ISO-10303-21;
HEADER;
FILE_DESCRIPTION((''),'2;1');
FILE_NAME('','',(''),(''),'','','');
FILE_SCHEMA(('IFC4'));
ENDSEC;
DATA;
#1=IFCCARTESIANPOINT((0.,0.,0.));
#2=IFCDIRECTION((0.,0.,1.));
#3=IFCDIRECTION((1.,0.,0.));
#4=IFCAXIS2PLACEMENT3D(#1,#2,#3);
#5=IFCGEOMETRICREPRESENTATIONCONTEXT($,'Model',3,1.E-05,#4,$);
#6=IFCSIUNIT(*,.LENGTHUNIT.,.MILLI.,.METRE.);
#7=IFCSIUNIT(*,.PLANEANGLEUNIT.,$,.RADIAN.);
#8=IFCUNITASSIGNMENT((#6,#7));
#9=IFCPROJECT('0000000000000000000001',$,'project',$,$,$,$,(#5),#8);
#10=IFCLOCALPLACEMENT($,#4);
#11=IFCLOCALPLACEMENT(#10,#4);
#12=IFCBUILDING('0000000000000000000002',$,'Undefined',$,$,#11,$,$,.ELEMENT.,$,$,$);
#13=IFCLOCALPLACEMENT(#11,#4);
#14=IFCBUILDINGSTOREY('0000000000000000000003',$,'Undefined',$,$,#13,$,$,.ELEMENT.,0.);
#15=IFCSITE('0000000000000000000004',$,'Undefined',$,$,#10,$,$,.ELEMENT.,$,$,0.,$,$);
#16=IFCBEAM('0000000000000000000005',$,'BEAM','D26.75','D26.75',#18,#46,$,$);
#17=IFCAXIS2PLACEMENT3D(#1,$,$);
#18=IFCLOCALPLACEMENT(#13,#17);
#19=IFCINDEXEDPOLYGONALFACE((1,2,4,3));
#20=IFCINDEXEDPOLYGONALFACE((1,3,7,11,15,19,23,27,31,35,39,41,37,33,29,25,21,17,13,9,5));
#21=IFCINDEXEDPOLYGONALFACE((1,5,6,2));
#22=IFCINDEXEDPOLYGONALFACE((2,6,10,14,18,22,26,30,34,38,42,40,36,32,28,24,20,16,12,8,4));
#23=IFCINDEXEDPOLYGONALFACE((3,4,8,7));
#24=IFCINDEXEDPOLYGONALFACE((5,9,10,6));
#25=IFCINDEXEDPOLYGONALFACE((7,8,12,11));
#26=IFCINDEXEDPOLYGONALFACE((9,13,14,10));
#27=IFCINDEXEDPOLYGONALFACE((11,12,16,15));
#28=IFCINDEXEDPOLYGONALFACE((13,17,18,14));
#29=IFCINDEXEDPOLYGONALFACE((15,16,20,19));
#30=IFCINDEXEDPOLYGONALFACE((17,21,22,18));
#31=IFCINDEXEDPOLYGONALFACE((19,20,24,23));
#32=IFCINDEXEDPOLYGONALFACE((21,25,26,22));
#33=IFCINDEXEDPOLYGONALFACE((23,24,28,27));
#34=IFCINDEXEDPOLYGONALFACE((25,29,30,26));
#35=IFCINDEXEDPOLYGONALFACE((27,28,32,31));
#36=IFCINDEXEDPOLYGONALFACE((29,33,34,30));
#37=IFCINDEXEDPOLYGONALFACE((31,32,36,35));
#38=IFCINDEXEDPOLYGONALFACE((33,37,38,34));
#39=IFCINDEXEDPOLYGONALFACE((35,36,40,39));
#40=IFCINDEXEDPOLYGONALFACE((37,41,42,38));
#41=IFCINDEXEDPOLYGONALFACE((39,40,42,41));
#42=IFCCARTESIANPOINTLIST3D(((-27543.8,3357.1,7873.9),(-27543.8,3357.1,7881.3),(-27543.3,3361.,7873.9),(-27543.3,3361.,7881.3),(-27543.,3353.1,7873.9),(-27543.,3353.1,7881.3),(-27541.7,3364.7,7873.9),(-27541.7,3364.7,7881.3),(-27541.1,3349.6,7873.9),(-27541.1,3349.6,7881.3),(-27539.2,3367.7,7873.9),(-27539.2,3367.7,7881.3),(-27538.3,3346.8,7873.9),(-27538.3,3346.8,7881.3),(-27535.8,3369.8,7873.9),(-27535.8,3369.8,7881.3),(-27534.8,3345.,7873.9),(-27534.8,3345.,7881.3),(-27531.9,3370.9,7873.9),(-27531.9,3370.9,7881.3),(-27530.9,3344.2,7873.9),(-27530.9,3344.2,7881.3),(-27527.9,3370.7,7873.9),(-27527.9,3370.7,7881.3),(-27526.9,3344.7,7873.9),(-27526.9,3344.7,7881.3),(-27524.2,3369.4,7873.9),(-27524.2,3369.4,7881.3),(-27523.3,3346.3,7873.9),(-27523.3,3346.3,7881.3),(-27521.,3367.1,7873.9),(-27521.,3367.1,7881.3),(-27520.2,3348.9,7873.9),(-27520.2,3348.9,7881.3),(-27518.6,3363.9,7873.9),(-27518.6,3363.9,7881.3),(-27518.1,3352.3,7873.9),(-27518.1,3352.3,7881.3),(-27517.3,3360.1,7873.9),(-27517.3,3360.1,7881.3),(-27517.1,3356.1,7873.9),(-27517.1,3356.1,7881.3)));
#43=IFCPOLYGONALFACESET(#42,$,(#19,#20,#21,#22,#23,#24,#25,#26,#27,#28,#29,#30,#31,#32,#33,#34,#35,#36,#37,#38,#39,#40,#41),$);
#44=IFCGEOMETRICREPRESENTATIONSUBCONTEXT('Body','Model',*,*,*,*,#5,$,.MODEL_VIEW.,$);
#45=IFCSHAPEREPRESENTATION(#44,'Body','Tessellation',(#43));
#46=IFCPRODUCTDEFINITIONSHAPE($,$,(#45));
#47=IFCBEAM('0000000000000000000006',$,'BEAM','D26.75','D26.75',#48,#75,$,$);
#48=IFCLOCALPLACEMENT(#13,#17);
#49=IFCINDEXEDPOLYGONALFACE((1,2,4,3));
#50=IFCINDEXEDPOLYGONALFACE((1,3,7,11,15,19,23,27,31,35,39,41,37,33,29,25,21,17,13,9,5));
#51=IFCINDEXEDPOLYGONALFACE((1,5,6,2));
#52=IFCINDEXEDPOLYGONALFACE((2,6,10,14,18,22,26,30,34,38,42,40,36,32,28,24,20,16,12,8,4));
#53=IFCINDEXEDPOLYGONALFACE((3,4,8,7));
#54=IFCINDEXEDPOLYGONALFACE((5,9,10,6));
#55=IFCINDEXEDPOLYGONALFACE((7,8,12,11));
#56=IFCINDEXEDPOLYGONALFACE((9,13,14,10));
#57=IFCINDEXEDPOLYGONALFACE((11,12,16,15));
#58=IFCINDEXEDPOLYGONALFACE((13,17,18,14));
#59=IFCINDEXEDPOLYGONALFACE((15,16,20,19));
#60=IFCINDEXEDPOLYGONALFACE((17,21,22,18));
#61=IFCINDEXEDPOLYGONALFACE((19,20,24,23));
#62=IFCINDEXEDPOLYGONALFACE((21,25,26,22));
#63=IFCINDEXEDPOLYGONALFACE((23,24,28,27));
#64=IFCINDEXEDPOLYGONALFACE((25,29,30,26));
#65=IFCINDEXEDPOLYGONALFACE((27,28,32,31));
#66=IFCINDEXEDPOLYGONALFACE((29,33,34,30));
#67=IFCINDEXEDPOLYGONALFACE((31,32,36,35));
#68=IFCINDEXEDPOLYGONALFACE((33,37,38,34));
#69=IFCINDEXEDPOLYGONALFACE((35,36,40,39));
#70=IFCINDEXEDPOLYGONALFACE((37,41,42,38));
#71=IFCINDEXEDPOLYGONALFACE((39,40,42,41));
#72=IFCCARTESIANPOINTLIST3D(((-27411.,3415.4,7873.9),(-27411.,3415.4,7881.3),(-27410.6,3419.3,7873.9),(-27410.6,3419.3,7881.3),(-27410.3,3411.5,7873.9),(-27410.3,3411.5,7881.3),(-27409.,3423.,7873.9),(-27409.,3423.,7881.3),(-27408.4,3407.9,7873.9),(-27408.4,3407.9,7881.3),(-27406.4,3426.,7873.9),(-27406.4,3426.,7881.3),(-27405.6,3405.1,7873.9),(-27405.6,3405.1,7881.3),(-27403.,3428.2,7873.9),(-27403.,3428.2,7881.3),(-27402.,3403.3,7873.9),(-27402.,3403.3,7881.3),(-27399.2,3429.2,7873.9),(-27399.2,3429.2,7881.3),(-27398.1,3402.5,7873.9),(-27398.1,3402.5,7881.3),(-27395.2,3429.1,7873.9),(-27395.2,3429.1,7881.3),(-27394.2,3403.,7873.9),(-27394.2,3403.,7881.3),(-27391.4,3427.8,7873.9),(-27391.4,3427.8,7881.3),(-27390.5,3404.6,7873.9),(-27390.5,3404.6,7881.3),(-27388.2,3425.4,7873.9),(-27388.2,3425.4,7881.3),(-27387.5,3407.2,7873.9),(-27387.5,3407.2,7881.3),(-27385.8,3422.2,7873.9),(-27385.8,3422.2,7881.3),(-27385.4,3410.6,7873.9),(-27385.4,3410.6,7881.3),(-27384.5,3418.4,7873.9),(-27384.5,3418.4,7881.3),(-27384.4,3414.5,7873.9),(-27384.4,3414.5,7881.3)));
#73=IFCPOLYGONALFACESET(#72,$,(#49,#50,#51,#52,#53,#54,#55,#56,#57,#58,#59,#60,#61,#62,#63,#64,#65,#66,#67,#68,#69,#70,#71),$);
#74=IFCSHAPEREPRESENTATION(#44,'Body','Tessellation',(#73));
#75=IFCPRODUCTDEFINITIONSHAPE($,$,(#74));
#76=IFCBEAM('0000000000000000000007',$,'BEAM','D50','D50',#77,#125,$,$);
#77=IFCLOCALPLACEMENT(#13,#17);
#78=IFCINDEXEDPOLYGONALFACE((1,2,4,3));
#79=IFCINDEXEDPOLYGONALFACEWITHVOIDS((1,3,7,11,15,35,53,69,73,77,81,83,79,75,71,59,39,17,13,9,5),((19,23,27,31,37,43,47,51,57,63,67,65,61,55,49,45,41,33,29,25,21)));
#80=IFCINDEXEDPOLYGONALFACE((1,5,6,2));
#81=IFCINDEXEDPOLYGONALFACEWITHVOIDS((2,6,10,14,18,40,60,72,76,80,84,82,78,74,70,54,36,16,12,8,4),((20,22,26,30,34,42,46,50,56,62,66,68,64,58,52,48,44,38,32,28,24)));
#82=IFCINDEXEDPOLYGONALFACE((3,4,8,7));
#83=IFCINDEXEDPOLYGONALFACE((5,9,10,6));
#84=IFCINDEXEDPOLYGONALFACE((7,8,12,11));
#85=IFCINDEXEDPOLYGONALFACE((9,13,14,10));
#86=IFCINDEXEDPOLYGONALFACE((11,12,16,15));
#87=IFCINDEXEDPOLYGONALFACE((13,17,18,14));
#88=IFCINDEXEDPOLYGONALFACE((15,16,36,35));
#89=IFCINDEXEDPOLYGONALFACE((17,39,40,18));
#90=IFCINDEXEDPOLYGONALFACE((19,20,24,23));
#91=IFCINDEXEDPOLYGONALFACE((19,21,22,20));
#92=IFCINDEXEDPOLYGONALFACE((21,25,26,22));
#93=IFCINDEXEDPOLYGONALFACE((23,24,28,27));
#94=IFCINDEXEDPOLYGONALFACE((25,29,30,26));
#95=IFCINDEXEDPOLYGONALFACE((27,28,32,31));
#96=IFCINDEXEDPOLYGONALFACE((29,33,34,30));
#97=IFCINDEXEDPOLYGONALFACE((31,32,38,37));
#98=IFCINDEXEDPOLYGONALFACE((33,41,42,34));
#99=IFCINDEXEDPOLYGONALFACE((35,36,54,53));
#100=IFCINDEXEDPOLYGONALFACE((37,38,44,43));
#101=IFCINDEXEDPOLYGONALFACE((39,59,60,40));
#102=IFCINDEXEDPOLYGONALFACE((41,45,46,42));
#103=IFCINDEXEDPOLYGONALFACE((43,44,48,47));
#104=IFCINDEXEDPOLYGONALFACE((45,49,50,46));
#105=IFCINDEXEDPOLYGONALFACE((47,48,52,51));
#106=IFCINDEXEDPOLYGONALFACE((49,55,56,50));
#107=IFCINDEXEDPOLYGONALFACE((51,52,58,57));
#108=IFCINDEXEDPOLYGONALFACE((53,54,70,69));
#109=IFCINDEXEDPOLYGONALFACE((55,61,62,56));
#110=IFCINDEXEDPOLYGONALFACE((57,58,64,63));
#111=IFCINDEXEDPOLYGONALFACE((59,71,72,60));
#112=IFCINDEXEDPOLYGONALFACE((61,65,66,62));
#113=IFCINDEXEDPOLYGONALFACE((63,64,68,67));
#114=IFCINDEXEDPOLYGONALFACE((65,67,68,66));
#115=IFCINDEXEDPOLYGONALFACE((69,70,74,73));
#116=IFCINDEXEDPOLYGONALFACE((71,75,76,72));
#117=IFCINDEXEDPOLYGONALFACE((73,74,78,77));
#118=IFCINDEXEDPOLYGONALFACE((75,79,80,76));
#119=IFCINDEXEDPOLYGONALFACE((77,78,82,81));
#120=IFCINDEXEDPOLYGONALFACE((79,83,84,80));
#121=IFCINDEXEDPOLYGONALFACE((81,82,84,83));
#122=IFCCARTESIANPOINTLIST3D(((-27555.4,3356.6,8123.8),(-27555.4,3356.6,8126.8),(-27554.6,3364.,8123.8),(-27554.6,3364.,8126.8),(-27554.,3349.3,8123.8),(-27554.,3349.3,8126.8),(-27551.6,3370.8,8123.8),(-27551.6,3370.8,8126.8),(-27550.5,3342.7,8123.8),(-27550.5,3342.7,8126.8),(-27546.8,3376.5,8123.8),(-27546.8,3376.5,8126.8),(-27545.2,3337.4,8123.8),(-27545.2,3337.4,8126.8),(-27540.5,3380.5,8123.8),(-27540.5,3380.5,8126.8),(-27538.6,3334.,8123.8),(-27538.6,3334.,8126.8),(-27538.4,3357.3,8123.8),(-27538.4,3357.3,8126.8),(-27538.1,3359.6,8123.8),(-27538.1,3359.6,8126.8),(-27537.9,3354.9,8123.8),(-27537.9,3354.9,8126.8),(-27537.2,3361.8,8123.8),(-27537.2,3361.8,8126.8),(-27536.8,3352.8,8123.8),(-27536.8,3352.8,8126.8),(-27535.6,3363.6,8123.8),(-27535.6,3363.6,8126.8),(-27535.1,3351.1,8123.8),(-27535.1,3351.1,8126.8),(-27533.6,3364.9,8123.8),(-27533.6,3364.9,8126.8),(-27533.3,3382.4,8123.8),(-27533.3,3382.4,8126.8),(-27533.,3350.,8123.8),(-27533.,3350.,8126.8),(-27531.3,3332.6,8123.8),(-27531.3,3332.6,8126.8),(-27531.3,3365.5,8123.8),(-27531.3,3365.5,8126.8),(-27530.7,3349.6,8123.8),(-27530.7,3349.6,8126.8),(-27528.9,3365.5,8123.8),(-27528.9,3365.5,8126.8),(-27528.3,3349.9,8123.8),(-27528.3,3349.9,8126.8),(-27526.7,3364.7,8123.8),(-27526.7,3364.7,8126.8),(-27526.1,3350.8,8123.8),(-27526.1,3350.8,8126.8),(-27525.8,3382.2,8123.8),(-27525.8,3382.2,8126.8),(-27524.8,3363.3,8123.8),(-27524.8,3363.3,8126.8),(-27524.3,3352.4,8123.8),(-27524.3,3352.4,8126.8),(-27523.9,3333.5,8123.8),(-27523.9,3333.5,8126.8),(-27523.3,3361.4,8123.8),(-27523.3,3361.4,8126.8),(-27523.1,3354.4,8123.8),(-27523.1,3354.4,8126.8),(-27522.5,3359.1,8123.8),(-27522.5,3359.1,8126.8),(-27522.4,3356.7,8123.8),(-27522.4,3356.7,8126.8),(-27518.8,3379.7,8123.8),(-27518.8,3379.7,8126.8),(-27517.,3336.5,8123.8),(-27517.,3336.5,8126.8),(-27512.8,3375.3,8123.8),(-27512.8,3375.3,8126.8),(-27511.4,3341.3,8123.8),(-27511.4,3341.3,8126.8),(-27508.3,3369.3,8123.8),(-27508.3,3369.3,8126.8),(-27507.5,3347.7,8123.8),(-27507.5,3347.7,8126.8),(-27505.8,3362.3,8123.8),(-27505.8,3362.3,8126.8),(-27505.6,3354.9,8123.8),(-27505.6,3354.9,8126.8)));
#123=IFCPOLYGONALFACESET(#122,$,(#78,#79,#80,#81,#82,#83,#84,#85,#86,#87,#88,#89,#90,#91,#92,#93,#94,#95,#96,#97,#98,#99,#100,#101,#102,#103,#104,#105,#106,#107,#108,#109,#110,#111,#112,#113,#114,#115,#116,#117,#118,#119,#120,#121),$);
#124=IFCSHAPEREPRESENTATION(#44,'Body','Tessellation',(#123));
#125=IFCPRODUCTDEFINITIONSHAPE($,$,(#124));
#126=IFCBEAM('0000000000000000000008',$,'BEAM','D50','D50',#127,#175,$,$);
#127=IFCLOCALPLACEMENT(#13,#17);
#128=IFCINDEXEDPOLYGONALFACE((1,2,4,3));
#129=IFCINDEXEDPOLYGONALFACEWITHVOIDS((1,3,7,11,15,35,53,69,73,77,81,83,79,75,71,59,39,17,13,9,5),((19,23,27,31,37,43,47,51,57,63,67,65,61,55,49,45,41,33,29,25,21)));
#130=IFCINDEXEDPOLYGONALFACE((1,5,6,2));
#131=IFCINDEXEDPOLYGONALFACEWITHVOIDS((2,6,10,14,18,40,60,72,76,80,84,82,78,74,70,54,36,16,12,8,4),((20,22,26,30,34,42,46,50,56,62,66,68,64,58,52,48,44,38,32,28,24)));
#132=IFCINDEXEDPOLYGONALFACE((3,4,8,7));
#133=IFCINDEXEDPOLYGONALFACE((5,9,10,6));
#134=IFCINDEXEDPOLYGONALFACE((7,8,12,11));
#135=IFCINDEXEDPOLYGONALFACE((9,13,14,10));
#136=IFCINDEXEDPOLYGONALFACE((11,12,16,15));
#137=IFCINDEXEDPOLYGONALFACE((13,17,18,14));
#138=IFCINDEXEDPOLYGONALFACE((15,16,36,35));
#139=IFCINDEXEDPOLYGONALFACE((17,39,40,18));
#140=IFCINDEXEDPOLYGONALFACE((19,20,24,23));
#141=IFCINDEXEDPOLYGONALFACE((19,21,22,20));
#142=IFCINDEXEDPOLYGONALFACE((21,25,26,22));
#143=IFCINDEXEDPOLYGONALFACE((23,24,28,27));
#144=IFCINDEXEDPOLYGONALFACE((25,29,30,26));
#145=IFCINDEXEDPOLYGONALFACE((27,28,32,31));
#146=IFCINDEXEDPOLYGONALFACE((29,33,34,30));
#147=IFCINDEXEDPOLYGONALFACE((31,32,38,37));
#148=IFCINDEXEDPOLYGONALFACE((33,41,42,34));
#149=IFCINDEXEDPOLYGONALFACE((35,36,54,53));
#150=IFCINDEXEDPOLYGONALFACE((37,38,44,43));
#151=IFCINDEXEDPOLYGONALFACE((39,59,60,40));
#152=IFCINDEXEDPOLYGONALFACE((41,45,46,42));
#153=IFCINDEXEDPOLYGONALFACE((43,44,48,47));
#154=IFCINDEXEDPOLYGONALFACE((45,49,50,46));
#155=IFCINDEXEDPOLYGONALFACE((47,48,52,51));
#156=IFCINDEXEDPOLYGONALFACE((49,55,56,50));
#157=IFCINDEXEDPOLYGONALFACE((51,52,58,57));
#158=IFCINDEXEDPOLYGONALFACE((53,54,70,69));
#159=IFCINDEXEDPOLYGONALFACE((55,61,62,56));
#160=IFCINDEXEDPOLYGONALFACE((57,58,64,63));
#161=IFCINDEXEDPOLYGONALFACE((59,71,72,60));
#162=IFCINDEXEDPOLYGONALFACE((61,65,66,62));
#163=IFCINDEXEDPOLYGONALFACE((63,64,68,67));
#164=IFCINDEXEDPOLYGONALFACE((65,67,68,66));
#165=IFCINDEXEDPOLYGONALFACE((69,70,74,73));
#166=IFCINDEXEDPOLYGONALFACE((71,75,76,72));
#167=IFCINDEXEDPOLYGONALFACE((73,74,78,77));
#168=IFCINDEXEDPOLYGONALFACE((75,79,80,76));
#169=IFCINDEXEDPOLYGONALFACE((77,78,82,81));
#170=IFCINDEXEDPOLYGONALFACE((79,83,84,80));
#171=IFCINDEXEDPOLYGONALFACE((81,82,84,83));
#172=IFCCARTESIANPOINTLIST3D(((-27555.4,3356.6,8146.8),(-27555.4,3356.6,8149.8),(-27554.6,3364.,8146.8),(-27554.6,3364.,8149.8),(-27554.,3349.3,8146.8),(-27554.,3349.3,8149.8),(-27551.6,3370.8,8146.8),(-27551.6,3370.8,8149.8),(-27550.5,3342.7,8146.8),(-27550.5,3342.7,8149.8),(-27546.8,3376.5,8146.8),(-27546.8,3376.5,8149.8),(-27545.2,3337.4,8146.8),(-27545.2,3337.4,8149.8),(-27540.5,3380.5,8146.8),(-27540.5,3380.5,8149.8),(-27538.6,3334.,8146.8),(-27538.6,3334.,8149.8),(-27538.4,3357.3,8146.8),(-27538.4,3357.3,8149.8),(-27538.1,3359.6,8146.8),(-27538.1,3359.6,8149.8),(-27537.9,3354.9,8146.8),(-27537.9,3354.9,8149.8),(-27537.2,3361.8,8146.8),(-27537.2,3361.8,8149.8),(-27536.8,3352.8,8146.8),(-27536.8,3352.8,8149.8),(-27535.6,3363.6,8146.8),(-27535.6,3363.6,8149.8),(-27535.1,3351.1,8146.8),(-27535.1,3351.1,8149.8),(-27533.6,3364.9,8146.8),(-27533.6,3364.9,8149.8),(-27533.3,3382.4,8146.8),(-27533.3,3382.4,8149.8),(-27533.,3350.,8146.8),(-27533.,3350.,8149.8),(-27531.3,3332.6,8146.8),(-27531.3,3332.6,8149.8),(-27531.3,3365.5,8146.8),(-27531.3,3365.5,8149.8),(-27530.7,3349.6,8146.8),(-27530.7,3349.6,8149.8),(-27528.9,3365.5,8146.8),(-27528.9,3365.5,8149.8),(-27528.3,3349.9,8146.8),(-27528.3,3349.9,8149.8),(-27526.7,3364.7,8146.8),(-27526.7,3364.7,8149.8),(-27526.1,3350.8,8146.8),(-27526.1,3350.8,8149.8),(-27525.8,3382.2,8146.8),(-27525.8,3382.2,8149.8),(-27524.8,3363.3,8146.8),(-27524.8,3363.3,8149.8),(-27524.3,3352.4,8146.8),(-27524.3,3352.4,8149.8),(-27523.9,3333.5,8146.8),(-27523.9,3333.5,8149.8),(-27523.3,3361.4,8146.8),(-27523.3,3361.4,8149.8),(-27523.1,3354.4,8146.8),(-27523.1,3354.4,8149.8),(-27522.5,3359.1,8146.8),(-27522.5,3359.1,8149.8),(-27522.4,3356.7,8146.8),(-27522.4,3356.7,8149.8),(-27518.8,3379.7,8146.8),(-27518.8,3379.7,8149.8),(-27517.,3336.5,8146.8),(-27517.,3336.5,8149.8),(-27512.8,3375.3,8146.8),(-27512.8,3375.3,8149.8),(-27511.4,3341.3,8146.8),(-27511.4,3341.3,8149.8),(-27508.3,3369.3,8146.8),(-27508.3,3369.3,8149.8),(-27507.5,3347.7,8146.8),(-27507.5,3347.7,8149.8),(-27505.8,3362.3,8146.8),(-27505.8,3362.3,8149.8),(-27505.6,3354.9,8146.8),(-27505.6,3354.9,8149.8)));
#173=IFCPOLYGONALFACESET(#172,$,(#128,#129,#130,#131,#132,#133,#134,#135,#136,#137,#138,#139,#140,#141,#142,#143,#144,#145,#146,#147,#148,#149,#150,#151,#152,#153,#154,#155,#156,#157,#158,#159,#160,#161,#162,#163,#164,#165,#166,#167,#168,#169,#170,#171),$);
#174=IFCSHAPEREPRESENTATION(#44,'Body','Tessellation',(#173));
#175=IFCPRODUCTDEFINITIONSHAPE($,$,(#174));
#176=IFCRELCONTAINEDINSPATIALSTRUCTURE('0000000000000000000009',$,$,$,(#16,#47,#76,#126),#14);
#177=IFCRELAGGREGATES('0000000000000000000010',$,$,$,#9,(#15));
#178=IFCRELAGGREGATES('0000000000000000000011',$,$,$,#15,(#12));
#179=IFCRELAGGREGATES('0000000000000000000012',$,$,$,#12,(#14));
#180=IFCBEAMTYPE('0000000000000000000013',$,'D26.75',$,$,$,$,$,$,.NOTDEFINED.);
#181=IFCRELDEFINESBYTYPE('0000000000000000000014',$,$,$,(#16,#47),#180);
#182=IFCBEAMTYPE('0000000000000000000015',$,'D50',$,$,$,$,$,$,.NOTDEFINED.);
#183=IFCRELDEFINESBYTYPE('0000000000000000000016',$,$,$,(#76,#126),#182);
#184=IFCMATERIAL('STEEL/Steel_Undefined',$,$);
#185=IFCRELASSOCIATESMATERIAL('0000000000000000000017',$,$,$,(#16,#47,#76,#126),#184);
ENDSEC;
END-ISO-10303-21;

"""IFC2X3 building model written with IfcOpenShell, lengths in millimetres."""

from ifc_helpers import new_model, si_unit, frame, origin_with_axes, origin_2d_with_axis, place, context, subcontext, project, spatial, circle, extrude, material, type_object, element, save


model = new_model("IFC2X3")

# Units and contexts
model_context = context("Model", 3, precision=1e-05, world=origin_with_axes())
body_context = subcontext(model_context, "Body", "Model", "MODEL_VIEW")
ifc_project = project(units=[si_unit("LENGTHUNIT", "METRE", prefix="MILLI"), si_unit("PLANEANGLEUNIT", "RADIAN")], contexts=[model_context])

# Site, building, storey
site_placement = place(None, origin_with_axes())
site = spatial("IfcSite", under=ifc_project, at=site_placement, Name="Undefined", CompositionType="ELEMENT", RefElevation=0.0)
building_placement = place(site_placement, origin_with_axes())
building = spatial("IfcBuilding", under=site, at=building_placement, Name="Undefined", CompositionType="ELEMENT")
storey_placement = place(building_placement, origin_with_axes())
storey = spatial("IfcBuildingStorey", under=building, at=storey_placement, Name="Undefined", CompositionType="ELEMENT", Elevation=0.0)

# Shared definitions
ifc_material = material(Name="STEEL/Steel_Undefined")
beam_type_1 = type_object("IfcBeamType", Name="D26.75", PredefinedType="NOTDEFINED")

# Beam
beam_1_placement = place(storey_placement, frame((-27530.4, 3357.6, 7881.3), z_axis=(-0.915553, -0.402198, 0.0), x_axis=(0.0, 0.0, -1.0)))
element("IfcBeam", 1, at=beam_1_placement, inside=storey, type_object=beam_type_1, material=ifc_material, Name="BEAM", Description="D26.75", ObjectType="D26.75", context=body_context, shape_type="SweptSolid", body=[
    extrude(circle(Radius=13.4, at=origin_2d_with_axis()), frame((7.4, 0.0, 0.0), z_axis=(-1.0, 0.0, 0.0), x_axis=(0.0, -1.0, 0.0)), (0.0, 0.0, 1.0), 7.4),
])

# Beam
beam_2_placement = place(storey_placement, frame((-27397.6, 3415.9, 7881.3), z_axis=(-0.915553, -0.402198, 0.0), x_axis=(0.0, 0.0, -1.0)))
element("IfcBeam", 2, at=beam_2_placement, inside=storey, type_object=beam_type_1, material=ifc_material, Name="BEAM", Description="D26.75", ObjectType="D26.75", context=body_context, shape_type="SweptSolid", body=[
    extrude(circle(Radius=13.4, at=origin_2d_with_axis()), frame((7.4, 0.0, 0.0), z_axis=(-1.0, 0.0, 0.0), x_axis=(0.0, -1.0, 0.0)), (0.0, 0.0, 1.0), 7.4),
])

# Beams, openings
beam_type_2 = type_object("IfcBeamType", Name="D50", PredefinedType="NOTDEFINED")
beam_3_placement = place(storey_placement, frame((-27530.4, 3357.6, 8126.8), z_axis=(-0.915553, -0.402198, 0.0), x_axis=(0.0, 0.0, -1.0)))
beam_3 = element("IfcBeam", 3, at=beam_3_placement, inside=storey, type_object=beam_type_2, material=ifc_material, Name="BEAM", Description="D50", ObjectType="D50", context=body_context, shape_type="SweptSolid", body=[
    extrude(circle(Radius=25.0, at=origin_2d_with_axis()), frame((3.0, 0.0, 0.0), z_axis=(-1.0, 0.0, 0.0), x_axis=(0.0, -1.0, 0.0)), (0.0, 0.0, 1.0), 3.0),
])
opening_1_placement = place(storey_placement, frame((-27530.4, 3357.6, 8126.8), z_axis=(-0.915553, -0.402198, 0.0), x_axis=(0.0, 0.0, -1.0)))
element("IfcOpeningElement", 4, at=opening_1_placement, cuts=beam_3, ObjectType="Recess", context=body_context, shape_type="SweptSolid", body=[
    extrude(circle(Radius=8.0, at=origin_2d_with_axis()), frame((245.5, 0.0, 0.0), z_axis=(-1.0, 0.0, 0.0), x_axis=(0.0, -1.0, 0.0)), (0.0, 0.0, 1.0), 292.6),
])
beam_4_placement = place(storey_placement, frame((-27530.4, 3357.6, 8149.8), z_axis=(-0.915553, -0.402198, 0.0), x_axis=(0.0, 0.0, -1.0)))
beam_4 = element("IfcBeam", 5, at=beam_4_placement, inside=storey, type_object=beam_type_2, material=ifc_material, Name="BEAM", Description="D50", ObjectType="D50", context=body_context, shape_type="SweptSolid", body=[
    extrude(circle(Radius=25.0, at=origin_2d_with_axis()), frame((3.0, 0.0, 0.0), z_axis=(-1.0, 0.0, 0.0), x_axis=(0.0, -1.0, 0.0)), (0.0, 0.0, 1.0), 3.0),
])
opening_2_placement = place(storey_placement, frame((-27530.4, 3357.6, 8149.8), z_axis=(-0.915553, -0.402198, 0.0), x_axis=(0.0, 0.0, -1.0)))
element("IfcOpeningElement", 6, at=opening_2_placement, cuts=beam_4, ObjectType="Recess", context=body_context, shape_type="SweptSolid", body=[
    extrude(circle(Radius=8.0, at=origin_2d_with_axis()), frame((268.5, 0.0, 0.0), z_axis=(-1.0, 0.0, 0.0), x_axis=(0.0, -1.0, 0.0)), (0.0, 0.0, 1.0), 292.6),
])

save(model, "model.ifc")
